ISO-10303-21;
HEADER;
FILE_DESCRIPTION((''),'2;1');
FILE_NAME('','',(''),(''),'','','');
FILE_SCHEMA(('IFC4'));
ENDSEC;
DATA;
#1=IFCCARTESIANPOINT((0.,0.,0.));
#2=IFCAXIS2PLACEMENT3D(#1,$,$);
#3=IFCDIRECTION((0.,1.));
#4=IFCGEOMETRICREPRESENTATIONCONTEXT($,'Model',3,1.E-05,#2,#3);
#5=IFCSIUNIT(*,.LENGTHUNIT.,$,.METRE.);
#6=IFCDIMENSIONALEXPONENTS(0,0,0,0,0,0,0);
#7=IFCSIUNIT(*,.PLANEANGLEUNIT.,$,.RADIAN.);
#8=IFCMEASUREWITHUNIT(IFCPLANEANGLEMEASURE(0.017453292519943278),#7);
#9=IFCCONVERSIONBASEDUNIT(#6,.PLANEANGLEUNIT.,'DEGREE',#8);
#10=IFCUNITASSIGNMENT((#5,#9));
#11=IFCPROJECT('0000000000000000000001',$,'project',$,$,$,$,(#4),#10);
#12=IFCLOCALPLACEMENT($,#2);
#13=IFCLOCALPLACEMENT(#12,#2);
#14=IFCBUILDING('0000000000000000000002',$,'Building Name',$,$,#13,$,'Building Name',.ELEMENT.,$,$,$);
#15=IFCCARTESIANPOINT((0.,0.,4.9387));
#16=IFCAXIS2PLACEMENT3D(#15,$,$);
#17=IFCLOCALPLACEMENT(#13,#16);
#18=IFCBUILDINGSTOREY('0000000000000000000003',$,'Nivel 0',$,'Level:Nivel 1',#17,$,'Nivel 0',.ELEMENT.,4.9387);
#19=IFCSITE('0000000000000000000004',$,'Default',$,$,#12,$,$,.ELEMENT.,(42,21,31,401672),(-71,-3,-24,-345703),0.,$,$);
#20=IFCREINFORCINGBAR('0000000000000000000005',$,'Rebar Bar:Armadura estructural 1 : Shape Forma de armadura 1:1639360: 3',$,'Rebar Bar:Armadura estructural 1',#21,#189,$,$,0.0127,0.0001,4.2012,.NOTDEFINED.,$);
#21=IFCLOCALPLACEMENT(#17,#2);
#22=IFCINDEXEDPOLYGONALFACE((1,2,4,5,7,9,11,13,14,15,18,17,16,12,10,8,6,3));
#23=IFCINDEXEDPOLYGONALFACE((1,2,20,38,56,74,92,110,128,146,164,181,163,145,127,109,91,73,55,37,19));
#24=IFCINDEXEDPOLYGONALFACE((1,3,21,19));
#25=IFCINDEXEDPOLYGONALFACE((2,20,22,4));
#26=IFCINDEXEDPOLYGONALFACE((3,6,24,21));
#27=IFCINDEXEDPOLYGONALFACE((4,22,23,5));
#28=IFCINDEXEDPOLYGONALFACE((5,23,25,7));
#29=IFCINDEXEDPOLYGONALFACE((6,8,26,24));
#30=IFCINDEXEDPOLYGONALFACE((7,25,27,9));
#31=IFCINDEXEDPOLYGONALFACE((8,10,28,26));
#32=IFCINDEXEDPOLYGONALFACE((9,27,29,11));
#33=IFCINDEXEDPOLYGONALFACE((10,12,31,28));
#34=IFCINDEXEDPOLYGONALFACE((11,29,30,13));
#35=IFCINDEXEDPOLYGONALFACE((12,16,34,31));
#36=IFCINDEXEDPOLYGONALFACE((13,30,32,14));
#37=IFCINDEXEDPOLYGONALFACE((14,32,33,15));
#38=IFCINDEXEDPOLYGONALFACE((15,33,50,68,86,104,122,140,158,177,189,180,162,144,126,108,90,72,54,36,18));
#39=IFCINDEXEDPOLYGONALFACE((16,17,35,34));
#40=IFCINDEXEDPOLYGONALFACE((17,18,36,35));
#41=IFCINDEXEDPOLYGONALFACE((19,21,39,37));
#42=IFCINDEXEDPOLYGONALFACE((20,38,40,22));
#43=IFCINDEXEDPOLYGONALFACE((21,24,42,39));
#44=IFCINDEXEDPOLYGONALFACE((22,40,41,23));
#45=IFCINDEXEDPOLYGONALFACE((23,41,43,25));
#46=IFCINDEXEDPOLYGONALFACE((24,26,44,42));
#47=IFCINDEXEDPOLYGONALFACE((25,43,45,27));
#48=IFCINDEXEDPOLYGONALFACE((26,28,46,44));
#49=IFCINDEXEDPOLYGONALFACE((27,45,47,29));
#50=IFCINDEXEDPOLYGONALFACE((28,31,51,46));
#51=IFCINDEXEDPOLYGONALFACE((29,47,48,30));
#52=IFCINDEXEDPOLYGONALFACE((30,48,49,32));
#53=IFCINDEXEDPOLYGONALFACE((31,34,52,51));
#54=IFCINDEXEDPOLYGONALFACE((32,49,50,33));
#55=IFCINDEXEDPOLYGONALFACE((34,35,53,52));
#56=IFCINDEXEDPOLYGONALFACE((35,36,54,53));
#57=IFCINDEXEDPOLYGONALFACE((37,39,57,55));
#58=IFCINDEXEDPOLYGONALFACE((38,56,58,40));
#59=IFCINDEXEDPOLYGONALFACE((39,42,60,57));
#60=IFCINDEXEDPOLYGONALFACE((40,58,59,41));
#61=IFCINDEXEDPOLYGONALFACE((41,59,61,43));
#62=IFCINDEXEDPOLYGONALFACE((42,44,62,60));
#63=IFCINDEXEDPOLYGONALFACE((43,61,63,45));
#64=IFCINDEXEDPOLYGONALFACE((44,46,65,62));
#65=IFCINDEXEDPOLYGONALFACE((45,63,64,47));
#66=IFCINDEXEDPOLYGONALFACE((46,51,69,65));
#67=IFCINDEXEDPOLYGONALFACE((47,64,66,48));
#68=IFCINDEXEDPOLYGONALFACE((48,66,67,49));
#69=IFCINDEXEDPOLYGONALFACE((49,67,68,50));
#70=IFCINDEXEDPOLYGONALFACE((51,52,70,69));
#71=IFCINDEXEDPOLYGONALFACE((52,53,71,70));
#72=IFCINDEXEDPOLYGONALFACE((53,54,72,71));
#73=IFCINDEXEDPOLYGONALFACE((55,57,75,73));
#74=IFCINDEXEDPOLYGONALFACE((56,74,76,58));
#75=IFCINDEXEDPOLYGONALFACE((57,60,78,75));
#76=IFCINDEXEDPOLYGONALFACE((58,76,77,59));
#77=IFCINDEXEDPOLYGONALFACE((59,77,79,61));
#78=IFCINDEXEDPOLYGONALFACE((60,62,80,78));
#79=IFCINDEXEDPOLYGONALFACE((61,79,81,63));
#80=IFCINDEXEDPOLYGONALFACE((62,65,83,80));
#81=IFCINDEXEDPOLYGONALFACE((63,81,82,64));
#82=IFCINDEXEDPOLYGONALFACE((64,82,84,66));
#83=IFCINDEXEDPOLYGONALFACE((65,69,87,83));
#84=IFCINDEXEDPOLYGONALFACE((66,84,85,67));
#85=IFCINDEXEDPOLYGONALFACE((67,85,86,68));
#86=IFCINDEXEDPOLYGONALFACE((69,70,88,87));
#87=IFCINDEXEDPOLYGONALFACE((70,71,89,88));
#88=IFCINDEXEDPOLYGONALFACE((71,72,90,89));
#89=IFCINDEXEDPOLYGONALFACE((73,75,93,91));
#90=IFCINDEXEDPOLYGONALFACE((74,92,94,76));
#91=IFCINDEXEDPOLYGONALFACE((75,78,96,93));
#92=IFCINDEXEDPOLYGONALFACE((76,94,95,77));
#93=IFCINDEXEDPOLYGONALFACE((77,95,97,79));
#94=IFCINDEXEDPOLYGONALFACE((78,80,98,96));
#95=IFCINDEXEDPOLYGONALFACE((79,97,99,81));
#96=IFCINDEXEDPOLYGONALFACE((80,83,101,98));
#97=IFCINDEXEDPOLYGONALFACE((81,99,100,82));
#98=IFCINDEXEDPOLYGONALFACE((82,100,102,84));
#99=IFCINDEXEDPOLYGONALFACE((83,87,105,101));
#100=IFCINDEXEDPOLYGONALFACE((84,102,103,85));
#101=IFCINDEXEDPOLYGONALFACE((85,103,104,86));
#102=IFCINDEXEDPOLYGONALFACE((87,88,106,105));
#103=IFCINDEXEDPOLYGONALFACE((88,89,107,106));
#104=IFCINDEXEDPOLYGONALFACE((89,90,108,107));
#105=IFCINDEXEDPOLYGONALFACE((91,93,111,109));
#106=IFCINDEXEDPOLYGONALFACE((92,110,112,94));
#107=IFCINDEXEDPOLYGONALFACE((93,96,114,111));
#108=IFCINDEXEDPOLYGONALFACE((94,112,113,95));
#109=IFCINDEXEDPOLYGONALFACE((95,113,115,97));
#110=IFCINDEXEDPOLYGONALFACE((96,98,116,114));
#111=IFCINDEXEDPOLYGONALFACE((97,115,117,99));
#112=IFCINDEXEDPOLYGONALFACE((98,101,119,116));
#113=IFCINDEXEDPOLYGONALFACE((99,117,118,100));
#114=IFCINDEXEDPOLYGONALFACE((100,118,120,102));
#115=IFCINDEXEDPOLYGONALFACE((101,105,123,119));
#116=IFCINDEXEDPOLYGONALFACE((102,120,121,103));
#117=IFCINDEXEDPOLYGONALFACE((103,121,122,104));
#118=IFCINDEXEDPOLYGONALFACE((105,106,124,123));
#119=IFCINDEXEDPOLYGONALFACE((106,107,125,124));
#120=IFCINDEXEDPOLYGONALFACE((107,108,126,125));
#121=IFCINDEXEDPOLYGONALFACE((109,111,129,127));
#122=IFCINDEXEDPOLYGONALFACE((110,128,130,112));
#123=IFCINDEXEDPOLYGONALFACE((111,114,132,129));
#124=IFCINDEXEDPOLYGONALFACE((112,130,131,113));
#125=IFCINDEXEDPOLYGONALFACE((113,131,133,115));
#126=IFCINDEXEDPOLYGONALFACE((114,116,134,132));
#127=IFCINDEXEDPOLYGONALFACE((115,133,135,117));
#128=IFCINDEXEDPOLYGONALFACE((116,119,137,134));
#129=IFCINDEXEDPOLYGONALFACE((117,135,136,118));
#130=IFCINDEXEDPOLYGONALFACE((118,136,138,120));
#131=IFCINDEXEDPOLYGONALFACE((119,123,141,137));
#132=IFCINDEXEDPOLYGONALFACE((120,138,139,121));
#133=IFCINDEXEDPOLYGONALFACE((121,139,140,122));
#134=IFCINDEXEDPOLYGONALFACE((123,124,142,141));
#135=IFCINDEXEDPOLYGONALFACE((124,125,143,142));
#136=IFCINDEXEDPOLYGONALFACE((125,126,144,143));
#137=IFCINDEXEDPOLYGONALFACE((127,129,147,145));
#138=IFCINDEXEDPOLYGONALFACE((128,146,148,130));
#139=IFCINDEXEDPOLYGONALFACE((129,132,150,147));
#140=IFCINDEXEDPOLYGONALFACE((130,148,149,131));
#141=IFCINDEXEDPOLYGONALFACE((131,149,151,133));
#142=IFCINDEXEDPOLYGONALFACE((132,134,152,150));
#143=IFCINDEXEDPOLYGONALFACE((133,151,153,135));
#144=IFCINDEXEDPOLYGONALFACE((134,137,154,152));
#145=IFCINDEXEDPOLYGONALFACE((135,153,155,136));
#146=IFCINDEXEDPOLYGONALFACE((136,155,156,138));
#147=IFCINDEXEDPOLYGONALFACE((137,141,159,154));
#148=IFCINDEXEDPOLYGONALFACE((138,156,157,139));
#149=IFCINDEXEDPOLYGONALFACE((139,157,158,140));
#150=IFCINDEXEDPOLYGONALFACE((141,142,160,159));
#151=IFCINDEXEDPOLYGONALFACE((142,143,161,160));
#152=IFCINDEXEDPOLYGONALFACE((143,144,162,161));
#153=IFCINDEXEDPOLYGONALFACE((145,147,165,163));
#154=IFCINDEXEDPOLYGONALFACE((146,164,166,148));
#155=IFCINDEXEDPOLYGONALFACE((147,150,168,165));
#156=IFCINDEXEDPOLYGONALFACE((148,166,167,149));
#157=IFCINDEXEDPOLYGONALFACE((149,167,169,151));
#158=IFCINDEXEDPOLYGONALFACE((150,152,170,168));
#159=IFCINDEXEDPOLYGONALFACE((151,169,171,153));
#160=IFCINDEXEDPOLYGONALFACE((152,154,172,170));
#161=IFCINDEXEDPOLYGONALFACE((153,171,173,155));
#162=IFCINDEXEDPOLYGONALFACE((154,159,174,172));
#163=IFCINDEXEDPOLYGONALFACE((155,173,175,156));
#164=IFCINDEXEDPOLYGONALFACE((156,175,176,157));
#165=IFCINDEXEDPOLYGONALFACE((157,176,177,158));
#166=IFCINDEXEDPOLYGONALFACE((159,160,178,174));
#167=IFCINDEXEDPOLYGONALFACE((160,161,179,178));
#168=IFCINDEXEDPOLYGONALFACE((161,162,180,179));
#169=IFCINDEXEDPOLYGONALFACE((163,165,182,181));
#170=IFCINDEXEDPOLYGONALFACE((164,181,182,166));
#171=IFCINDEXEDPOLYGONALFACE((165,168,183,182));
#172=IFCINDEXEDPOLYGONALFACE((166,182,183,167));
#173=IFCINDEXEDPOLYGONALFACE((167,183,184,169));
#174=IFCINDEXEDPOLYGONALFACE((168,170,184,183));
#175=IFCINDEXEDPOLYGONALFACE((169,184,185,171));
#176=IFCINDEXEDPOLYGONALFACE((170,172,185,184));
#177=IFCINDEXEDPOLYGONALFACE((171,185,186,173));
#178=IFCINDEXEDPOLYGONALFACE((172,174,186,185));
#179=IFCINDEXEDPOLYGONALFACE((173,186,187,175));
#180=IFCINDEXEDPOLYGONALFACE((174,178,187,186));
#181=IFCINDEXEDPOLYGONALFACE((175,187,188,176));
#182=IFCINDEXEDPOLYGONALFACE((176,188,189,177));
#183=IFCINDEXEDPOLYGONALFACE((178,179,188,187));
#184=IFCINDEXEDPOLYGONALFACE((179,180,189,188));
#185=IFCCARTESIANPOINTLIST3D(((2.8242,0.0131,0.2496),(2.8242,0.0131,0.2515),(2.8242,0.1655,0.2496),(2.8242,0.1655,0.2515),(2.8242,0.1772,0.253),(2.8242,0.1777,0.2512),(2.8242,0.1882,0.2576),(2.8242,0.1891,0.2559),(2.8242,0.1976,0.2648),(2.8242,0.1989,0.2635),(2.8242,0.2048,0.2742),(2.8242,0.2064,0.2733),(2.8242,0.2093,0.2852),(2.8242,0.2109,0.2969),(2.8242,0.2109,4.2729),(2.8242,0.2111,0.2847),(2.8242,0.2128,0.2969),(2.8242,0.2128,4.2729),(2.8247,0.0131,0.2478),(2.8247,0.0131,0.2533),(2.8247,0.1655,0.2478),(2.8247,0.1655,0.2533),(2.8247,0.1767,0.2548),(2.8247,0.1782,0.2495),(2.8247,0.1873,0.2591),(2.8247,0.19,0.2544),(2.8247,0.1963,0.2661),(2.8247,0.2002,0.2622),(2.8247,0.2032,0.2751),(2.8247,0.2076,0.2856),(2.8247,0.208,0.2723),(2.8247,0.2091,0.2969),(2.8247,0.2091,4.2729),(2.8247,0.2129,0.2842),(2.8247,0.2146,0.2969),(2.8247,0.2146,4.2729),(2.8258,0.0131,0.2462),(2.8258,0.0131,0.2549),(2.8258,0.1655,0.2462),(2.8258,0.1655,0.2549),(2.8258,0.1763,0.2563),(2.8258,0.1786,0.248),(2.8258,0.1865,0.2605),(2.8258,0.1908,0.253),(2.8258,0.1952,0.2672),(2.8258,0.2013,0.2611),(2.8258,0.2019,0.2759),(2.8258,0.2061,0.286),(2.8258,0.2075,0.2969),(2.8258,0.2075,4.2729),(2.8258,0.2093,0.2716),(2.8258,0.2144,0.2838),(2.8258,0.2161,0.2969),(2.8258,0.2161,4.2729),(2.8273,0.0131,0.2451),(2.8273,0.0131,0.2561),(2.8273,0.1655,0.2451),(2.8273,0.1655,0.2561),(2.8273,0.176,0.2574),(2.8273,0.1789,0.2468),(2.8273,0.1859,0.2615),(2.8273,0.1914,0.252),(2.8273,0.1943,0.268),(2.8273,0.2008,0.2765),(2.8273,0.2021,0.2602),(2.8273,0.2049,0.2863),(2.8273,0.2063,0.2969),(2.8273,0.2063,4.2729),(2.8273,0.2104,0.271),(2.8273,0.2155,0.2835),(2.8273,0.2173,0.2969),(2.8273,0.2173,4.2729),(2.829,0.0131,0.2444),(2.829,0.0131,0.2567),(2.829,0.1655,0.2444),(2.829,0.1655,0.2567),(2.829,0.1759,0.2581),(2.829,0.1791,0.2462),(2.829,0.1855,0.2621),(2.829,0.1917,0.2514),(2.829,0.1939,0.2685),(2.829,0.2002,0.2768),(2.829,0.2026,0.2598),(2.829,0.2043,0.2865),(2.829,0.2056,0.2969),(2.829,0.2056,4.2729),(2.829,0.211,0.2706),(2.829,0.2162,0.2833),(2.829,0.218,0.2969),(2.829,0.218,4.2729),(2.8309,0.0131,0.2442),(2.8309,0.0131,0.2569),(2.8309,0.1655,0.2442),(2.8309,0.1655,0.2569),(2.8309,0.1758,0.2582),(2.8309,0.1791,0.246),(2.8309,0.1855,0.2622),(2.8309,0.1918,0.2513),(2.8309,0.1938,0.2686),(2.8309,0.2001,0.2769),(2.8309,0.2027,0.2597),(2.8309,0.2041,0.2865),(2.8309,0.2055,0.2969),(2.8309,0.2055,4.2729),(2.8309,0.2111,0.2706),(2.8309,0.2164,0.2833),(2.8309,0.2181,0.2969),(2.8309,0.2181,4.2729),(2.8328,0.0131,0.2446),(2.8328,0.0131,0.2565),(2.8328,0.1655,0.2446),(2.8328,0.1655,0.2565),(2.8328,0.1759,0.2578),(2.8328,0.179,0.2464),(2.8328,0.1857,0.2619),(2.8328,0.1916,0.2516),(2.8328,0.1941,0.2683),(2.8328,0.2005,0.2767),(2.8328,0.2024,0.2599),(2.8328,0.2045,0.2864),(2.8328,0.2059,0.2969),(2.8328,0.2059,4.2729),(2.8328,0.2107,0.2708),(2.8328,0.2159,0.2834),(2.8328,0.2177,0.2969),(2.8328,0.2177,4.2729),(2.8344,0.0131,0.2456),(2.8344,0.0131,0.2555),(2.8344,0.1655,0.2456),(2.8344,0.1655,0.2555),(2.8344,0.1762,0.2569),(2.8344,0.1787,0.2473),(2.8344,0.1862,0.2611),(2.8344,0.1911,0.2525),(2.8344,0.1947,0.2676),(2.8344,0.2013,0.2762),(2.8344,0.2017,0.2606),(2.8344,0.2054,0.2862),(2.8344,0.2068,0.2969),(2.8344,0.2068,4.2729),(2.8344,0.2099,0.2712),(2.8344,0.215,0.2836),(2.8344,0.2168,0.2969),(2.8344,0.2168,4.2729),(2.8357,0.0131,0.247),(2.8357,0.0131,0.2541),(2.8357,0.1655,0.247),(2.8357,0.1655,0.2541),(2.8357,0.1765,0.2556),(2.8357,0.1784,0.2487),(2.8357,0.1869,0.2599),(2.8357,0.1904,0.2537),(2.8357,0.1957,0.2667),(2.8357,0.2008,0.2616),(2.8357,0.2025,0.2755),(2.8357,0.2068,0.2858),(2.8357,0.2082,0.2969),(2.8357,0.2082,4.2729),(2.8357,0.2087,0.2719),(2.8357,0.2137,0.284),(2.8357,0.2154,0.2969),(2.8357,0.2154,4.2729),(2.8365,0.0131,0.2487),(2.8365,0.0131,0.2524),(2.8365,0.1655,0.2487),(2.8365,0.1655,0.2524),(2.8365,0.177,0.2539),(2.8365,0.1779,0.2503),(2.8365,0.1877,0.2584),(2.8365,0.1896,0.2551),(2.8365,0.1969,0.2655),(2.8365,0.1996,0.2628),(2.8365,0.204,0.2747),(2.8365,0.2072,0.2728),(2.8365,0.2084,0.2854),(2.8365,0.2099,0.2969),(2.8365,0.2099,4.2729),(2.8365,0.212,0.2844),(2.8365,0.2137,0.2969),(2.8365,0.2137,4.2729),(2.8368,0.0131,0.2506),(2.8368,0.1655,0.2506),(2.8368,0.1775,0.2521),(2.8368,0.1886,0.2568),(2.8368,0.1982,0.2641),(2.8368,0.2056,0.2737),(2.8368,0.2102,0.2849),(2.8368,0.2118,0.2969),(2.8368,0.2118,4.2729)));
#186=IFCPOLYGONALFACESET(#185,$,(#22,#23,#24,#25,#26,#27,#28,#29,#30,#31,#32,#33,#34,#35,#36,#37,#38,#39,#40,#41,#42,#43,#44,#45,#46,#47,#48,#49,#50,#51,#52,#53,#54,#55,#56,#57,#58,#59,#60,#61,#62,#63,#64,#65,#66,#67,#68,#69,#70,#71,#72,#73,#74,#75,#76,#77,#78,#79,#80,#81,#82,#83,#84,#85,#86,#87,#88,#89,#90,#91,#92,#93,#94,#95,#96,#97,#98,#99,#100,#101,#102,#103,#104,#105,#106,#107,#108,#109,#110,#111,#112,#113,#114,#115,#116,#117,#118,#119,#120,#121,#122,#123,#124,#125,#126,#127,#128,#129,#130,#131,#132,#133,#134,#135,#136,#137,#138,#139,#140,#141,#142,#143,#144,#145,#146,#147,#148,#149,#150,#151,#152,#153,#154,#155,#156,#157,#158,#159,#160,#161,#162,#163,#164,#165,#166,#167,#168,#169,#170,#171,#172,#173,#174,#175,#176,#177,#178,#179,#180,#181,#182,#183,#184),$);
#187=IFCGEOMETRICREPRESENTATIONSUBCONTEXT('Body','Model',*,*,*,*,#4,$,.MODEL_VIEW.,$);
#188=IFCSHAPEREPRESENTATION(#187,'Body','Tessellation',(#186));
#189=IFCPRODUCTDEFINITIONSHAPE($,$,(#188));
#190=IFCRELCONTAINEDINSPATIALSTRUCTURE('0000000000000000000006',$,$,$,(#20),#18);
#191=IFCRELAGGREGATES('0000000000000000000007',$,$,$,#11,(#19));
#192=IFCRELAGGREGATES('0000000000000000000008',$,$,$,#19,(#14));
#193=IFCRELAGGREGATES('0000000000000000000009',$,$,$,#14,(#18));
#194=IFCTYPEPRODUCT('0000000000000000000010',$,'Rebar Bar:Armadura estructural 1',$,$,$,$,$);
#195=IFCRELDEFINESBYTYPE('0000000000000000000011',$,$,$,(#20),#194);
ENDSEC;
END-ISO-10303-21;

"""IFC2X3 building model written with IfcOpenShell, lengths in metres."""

from ifc_helpers import new_model, entity, si_unit, converted_unit, direction, frame, origin, place, context, subcontext, project, spatial, type_object, element, save


model = new_model("IFC2X3")

# Units and contexts
model_context = context("Model", 3, precision=1e-05, world=origin(), true_north=direction((0.0, 1.0)))
body_context = subcontext(model_context, "Body", "Model", "MODEL_VIEW")
ifc_project = project(units=[si_unit("LENGTHUNIT", "METRE"), converted_unit("PLANEANGLEUNIT", "DEGREE", entity("IfcPlaneAngleMeasure", 0.017453292519943278), si_unit("PLANEANGLEUNIT", "RADIAN"), dimensions=[0, 0, 0, 0, 0, 0, 0])], contexts=[model_context])

# Site, building, storey
site_placement = place(None, origin())
site = spatial("IfcSite", under=ifc_project, at=site_placement, Name="Default", CompositionType="ELEMENT", RefLatitude=(42, 21, 31, 401672), RefLongitude=(-71, -3, -24, -345703), RefElevation=0.0)
building_placement = place(site_placement, origin())
building = spatial("IfcBuilding", under=site, at=building_placement, Name="Building Name", LongName="Building Name", CompositionType="ELEMENT")
storey_placement = place(building_placement, frame((0.0, 0.0, 4.9387)))
storey = spatial("IfcBuildingStorey", under=building, at=storey_placement, Name="Nivel 0", ObjectType="Level:Nivel 1", LongName="Nivel 0", CompositionType="ELEMENT", Elevation=4.9387)

# Reinforcing bar
type_product = type_object("IfcTypeProduct", Name="Rebar Bar:Armadura estructural 1")
reinforcing_bar_1_placement = place(storey_placement, origin())
element("IfcReinforcingBar", 1, at=reinforcing_bar_1_placement, inside=storey, type_object=type_product, Name="Rebar Bar:Armadura estructural 1 : Shape Forma de armadura 1:1639360: 3", ObjectType="Rebar Bar:Armadura estructural 1", BarLength=4.2012, BarRole="NOTDEFINED", CrossSectionArea=0.0001, NominalDiameter=0.0127, context=body_context, shape_type="AdvancedSweptSolid", body=[
    entity("IfcSweptDiskSolid", entity("IfcCompositeCurve", [entity("IfcCompositeCurveSegment", "CONTINUOUS", True, entity("IfcPolyline", [entity("IfcCartesianPoint", [2.8305, 0.0131, 0.2506]), entity("IfcCartesianPoint", [2.8305, 0.1655, 0.2506])])), entity("IfcCompositeCurveSegment", "CONTINUOUS", True, entity("IfcTrimmedCurve", entity("IfcCircle", entity("IfcAxis2Placement3D", entity("IfcCartesianPoint", [2.8305, 0.1655, 0.2969]), entity("IfcDirection", [1.0, 0.0, 0.0]), entity("IfcDirection", [0.0, 1.0, 0.0])), 0.0464), [entity("IfcParameterValue", 270.0)], [entity("IfcParameterValue", 360.0)], True, "PARAMETER")), entity("IfcCompositeCurveSegment", "CONTINUOUS", True, entity("IfcPolyline", [entity("IfcCartesianPoint", [2.8305, 0.2118, 0.2969]), entity("IfcCartesianPoint", [2.8305, 0.2118, 4.2729])]))], False), 0.0063, None, 0.0, 92.0),
])

save(model, "model.ifc")
